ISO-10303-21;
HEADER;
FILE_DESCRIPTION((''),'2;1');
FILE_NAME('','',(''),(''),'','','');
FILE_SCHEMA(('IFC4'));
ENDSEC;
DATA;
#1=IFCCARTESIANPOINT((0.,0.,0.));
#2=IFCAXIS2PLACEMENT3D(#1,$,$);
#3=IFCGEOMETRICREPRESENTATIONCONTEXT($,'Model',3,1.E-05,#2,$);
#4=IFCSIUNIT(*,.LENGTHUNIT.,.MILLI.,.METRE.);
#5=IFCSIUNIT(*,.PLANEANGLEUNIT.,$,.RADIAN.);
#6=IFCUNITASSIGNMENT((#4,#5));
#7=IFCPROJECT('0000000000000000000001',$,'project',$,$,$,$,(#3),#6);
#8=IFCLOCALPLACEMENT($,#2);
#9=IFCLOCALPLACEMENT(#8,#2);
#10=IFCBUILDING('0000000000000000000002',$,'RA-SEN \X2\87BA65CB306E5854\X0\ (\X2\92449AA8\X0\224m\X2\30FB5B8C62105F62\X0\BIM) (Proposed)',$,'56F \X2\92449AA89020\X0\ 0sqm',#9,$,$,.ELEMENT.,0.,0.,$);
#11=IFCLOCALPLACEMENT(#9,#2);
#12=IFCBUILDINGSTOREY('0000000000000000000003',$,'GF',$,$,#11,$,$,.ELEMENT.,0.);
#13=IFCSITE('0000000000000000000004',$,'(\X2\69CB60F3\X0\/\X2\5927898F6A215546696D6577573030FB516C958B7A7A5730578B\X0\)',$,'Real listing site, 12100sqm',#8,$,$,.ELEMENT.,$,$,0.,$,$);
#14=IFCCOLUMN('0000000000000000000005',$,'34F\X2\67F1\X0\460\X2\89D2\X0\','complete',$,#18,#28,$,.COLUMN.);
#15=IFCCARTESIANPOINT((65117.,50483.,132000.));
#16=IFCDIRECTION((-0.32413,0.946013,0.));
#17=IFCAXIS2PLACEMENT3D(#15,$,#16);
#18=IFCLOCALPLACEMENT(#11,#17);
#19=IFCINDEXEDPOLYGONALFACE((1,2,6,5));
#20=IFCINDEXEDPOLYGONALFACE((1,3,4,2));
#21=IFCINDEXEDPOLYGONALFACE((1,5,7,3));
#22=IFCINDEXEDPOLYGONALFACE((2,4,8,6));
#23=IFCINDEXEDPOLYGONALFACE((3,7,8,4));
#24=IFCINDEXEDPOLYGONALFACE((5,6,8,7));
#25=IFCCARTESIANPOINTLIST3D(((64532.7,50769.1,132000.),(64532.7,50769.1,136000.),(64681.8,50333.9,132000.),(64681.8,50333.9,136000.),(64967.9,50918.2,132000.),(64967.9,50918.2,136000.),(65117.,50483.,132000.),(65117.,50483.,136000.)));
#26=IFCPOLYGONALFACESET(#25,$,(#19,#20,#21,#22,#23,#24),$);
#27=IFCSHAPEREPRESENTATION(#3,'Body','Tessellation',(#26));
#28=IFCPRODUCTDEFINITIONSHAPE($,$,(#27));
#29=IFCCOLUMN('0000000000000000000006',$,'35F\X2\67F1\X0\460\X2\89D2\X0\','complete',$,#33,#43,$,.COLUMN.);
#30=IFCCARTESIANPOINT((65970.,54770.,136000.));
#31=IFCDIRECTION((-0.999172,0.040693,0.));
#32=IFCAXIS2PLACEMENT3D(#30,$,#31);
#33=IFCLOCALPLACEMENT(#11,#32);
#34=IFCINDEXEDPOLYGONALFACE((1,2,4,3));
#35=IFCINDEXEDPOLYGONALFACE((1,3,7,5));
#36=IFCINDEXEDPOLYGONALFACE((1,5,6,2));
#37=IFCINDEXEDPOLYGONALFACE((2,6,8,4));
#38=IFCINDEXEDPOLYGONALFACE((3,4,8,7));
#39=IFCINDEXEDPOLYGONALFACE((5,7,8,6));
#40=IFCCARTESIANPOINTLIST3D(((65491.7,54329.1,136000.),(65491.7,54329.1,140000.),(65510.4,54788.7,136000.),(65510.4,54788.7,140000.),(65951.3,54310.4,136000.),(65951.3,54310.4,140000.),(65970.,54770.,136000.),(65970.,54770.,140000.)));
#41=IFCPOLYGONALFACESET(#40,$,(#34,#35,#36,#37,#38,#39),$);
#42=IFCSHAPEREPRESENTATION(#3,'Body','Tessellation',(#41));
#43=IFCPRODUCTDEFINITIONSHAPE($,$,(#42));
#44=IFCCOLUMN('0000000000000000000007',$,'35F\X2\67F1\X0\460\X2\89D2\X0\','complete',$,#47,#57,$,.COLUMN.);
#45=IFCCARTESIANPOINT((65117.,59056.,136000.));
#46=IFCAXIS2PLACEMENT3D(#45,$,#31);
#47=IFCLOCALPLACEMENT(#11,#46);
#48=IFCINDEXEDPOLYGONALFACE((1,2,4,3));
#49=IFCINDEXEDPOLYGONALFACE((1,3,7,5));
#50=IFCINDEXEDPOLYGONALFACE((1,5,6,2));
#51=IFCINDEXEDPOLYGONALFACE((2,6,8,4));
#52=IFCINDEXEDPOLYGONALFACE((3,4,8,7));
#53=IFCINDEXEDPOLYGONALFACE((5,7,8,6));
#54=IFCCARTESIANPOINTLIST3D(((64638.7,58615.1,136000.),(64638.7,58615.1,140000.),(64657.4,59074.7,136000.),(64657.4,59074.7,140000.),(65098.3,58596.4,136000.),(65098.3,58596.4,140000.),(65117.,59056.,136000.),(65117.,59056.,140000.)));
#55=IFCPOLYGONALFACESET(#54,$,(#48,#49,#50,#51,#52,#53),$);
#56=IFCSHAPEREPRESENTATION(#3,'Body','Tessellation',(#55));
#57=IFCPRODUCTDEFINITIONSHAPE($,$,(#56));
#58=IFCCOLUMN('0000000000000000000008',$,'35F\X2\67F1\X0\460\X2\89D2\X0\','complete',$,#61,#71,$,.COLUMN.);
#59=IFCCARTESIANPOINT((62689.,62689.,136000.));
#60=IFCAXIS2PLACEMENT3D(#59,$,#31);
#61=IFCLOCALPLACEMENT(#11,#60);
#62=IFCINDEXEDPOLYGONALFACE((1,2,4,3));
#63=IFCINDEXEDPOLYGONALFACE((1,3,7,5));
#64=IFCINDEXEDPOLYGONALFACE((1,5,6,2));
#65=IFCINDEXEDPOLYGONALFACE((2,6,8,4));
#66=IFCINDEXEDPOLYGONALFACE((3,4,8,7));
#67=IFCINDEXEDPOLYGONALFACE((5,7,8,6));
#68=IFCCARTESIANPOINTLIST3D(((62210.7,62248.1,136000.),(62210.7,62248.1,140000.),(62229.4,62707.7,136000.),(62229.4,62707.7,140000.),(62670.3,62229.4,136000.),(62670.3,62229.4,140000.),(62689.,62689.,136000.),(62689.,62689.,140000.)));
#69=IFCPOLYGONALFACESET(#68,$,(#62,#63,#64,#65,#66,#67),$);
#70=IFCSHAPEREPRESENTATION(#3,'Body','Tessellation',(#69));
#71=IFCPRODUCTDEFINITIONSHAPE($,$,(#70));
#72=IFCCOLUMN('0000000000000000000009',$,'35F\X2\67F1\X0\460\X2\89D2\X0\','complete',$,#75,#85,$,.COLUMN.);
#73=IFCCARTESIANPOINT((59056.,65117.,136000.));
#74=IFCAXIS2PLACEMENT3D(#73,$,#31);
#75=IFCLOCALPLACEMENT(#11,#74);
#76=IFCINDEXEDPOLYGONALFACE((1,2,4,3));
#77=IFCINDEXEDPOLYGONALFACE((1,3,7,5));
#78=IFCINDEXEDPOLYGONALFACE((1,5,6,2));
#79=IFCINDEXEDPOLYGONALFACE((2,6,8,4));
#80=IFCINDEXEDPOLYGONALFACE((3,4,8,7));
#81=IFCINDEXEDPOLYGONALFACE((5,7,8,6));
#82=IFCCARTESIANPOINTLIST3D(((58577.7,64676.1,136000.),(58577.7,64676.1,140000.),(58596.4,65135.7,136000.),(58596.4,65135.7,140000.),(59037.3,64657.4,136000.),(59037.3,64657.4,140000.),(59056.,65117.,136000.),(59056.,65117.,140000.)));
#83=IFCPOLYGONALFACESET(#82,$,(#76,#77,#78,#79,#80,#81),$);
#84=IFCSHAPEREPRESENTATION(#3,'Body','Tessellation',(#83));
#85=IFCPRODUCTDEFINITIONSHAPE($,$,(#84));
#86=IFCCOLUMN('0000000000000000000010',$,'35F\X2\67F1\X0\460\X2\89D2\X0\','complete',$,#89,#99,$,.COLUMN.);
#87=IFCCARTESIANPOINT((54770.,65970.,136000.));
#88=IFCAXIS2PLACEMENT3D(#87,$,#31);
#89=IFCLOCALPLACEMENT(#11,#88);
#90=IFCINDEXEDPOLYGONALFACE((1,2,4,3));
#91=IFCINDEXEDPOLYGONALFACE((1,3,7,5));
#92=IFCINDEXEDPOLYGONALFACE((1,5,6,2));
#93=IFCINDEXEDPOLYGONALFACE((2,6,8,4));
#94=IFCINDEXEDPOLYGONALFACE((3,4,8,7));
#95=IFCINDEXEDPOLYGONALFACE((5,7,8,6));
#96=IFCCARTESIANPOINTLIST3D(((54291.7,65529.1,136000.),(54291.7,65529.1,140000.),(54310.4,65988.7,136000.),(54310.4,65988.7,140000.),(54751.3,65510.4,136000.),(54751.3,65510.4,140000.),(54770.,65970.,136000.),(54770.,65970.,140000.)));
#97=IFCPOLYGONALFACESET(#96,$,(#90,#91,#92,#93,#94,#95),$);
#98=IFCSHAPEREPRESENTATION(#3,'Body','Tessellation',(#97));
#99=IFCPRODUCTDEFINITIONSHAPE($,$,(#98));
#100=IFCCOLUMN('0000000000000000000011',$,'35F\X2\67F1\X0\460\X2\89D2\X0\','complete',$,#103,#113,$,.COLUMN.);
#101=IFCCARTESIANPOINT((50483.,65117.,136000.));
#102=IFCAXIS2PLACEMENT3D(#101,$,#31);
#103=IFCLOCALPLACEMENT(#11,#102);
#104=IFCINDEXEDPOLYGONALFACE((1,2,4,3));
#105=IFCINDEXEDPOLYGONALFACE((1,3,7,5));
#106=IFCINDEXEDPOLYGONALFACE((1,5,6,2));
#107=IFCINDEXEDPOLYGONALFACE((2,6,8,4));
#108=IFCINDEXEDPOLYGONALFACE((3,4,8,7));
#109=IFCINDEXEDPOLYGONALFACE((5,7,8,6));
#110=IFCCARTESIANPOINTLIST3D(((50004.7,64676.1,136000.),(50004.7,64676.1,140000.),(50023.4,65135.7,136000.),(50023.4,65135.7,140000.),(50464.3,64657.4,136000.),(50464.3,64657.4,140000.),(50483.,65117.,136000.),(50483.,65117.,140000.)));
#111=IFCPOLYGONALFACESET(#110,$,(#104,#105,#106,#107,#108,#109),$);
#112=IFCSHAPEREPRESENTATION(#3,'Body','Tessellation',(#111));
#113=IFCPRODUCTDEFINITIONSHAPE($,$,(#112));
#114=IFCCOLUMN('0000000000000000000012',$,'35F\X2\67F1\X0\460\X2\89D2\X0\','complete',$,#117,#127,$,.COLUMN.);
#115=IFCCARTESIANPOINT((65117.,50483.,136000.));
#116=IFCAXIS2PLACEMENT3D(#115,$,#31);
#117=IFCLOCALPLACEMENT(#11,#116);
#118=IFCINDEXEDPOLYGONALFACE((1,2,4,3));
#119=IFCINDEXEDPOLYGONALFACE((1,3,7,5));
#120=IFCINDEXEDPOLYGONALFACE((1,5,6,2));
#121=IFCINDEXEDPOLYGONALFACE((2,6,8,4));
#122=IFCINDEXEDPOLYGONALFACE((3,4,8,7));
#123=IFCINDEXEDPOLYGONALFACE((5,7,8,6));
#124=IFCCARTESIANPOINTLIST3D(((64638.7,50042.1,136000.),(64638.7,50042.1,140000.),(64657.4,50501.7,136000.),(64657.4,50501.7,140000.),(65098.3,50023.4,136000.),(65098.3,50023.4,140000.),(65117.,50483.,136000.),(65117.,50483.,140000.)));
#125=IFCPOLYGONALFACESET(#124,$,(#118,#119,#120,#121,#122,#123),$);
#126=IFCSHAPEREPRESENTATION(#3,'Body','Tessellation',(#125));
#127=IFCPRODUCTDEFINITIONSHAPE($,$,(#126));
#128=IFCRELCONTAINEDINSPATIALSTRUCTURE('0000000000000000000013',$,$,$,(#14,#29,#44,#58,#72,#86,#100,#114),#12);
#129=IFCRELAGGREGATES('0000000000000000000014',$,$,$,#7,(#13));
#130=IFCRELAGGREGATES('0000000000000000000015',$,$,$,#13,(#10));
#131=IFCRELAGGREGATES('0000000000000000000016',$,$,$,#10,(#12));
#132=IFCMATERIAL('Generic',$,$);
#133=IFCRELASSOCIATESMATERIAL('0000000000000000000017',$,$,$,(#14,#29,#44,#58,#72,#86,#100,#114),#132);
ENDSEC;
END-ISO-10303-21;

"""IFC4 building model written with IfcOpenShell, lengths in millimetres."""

from ifc_helpers import new_model, si_unit, frame, frame_2d, origin, place, context, project, spatial, rectangle, extrude, material, element, save


model = new_model("IFC4")

# Units and contexts
model_context = context("Model", 3, precision=1e-05, world=origin())
ifc_project = project(units=[si_unit("LENGTHUNIT", "METRE", prefix="MILLI"), si_unit("PLANEANGLEUNIT", "RADIAN")], contexts=[model_context])

# Site, building, storey
site_placement = place(None, origin())
site = spatial("IfcSite", under=ifc_project, at=site_placement, Name="(構想/大規模商業敷地・公開空地型)", ObjectType="Real listing site, 12100sqm", CompositionType="ELEMENT", RefElevation=0.0)
building_placement = place(site_placement, origin())
building = spatial("IfcBuilding", under=site, at=building_placement, Name="RA-SEN 螺旋の塔 (鉄骨224m・完成形BIM) (Proposed)", ObjectType="56F 鉄骨造 0sqm", CompositionType="ELEMENT", ElevationOfRefHeight=0.0, ElevationOfTerrain=0.0)
storey_placement = place(building_placement, origin())
storey = spatial("IfcBuildingStorey", under=building, at=storey_placement, Name="GF", CompositionType="ELEMENT", Elevation=0.0)

# Columns
ifc_material = material(Name="Generic")
column_1_placement = place(storey_placement, frame((65117.0, 50483.0, 132000.0), x_axis=(-0.32413, 0.946013, 0.0)))
element("IfcColumn", 1, at=column_1_placement, inside=storey, material=ifc_material, Name="34F柱460角", Description="complete", PredefinedType="COLUMN", context=model_context, shape_type="SweptSolid", body=[
    extrude(rectangle(XDim=460.0, YDim=460.0, at=frame_2d((230.0, 230.0))), frame((65117.0, 50483.0, 132000.0), x_axis=(-0.32413, 0.946013, 0.0)), (0.0, 0.0, 1.0), 4000.0),
])
column_2_placement = place(storey_placement, frame((65970.0, 54770.0, 136000.0), x_axis=(-0.999172, 0.040693, 0.0)))
element("IfcColumn", 2, at=column_2_placement, inside=storey, material=ifc_material, Name="35F柱460角", Description="complete", PredefinedType="COLUMN", context=model_context, shape_type="SweptSolid", body=[
    extrude(rectangle(XDim=460.0, YDim=460.0, at=frame_2d((230.0, 230.0))), frame((65970.0, 54770.0, 136000.0), x_axis=(-0.999172, 0.040693, 0.0)), (0.0, 0.0, 1.0), 4000.0),
])
column_3_placement = place(storey_placement, frame((65117.0, 59056.0, 136000.0), x_axis=(-0.999172, 0.040693, 0.0)))
element("IfcColumn", 3, at=column_3_placement, inside=storey, material=ifc_material, Name="35F柱460角", Description="complete", PredefinedType="COLUMN", context=model_context, shape_type="SweptSolid", body=[
    extrude(rectangle(XDim=460.0, YDim=460.0, at=frame_2d((230.0, 230.0))), frame((65117.0, 59056.0, 136000.0), x_axis=(-0.999172, 0.040693, 0.0)), (0.0, 0.0, 1.0), 4000.0),
])
column_4_placement = place(storey_placement, frame((62689.0, 62689.0, 136000.0), x_axis=(-0.999172, 0.040693, 0.0)))
element("IfcColumn", 4, at=column_4_placement, inside=storey, material=ifc_material, Name="35F柱460角", Description="complete", PredefinedType="COLUMN", context=model_context, shape_type="SweptSolid", body=[
    extrude(rectangle(XDim=460.0, YDim=460.0, at=frame_2d((230.0, 230.0))), frame((62689.0, 62689.0, 136000.0), x_axis=(-0.999172, 0.040693, 0.0)), (0.0, 0.0, 1.0), 4000.0),
])
column_5_placement = place(storey_placement, frame((59056.0, 65117.0, 136000.0), x_axis=(-0.999172, 0.040693, 0.0)))
element("IfcColumn", 5, at=column_5_placement, inside=storey, material=ifc_material, Name="35F柱460角", Description="complete", PredefinedType="COLUMN", context=model_context, shape_type="SweptSolid", body=[
    extrude(rectangle(XDim=460.0, YDim=460.0, at=frame_2d((230.0, 230.0))), frame((59056.0, 65117.0, 136000.0), x_axis=(-0.999172, 0.040693, 0.0)), (0.0, 0.0, 1.0), 4000.0),
])
column_6_placement = place(storey_placement, frame((54770.0, 65970.0, 136000.0), x_axis=(-0.999172, 0.040693, 0.0)))
element("IfcColumn", 6, at=column_6_placement, inside=storey, material=ifc_material, Name="35F柱460角", Description="complete", PredefinedType="COLUMN", context=model_context, shape_type="SweptSolid", body=[
    extrude(rectangle(XDim=460.0, YDim=460.0, at=frame_2d((230.0, 230.0))), frame((54770.0, 65970.0, 136000.0), x_axis=(-0.999172, 0.040693, 0.0)), (0.0, 0.0, 1.0), 4000.0),
])
column_7_placement = place(storey_placement, frame((50483.0, 65117.0, 136000.0), x_axis=(-0.999172, 0.040693, 0.0)))
element("IfcColumn", 7, at=column_7_placement, inside=storey, material=ifc_material, Name="35F柱460角", Description="complete", PredefinedType="COLUMN", context=model_context, shape_type="SweptSolid", body=[
    extrude(rectangle(XDim=460.0, YDim=460.0, at=frame_2d((230.0, 230.0))), frame((50483.0, 65117.0, 136000.0), x_axis=(-0.999172, 0.040693, 0.0)), (0.0, 0.0, 1.0), 4000.0),
])
column_8_placement = place(storey_placement, frame((65117.0, 50483.0, 136000.0), x_axis=(-0.999172, 0.040693, 0.0)))
element("IfcColumn", 8, at=column_8_placement, inside=storey, material=ifc_material, Name="35F柱460角", Description="complete", PredefinedType="COLUMN", context=model_context, shape_type="SweptSolid", body=[
    extrude(rectangle(XDim=460.0, YDim=460.0, at=frame_2d((230.0, 230.0))), frame((65117.0, 50483.0, 136000.0), x_axis=(-0.999172, 0.040693, 0.0)), (0.0, 0.0, 1.0), 4000.0),
])

save(model, "model.ifc")
